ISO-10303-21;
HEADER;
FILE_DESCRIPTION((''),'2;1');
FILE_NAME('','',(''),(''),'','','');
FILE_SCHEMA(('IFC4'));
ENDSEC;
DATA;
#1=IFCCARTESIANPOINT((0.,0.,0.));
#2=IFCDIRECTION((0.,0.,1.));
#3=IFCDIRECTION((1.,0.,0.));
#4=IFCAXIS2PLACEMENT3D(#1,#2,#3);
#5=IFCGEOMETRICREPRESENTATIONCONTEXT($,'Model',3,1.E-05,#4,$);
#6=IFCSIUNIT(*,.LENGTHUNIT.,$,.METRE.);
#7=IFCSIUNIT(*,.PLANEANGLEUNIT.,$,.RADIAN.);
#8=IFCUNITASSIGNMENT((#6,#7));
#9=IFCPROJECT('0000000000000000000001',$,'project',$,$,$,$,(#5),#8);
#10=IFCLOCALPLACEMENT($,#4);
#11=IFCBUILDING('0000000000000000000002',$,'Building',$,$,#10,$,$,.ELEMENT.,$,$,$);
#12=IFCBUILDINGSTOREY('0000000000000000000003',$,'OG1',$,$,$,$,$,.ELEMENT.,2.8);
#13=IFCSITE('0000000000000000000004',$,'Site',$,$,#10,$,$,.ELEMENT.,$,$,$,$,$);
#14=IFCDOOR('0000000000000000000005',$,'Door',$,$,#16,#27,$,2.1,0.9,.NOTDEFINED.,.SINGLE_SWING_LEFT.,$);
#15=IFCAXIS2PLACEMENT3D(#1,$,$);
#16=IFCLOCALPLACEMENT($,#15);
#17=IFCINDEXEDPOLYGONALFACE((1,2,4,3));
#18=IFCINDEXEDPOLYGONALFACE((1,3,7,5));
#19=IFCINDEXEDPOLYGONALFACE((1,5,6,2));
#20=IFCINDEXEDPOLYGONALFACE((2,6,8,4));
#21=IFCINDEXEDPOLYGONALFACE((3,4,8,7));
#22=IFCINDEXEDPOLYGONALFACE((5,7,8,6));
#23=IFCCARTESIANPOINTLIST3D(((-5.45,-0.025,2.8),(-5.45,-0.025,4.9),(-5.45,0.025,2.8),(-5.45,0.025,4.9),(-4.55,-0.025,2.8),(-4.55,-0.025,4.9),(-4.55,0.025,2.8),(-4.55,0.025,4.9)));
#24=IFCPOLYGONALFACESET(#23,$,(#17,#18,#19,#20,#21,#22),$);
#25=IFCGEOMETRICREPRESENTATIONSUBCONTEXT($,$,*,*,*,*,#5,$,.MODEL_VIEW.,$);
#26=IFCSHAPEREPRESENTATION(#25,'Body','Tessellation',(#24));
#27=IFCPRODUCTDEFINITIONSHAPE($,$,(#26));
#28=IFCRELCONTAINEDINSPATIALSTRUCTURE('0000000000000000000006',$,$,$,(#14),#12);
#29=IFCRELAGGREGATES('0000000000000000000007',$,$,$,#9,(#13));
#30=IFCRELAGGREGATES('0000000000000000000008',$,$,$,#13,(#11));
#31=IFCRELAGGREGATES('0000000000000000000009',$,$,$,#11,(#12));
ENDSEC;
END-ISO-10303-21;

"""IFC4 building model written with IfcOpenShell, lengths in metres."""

from ifc_helpers import new_model, si_unit, frame, origin, origin_with_axes, origin_2d, place, context, subcontext, project, spatial, rectangle, extrude, element, save


model = new_model("IFC4")

# Units and contexts
model_context = context("Model", 3, precision=1e-05, world=origin_with_axes())
sub_context = subcontext(model_context, None, None, "MODEL_VIEW")
ifc_project = project(units=[si_unit("LENGTHUNIT", "METRE"), si_unit("PLANEANGLEUNIT", "RADIAN")], contexts=[model_context])

# Site, building, storey
placement_1 = place(None, origin_with_axes())
site = spatial("IfcSite", under=ifc_project, at=placement_1, Name="Site", CompositionType="ELEMENT")
building = spatial("IfcBuilding", under=site, at=placement_1, Name="Building", CompositionType="ELEMENT")
storey = spatial("IfcBuildingStorey", under=building, Name="OG1", CompositionType="ELEMENT", Elevation=2.8)

# Door
placement_2 = place(None, origin_with_axes())
door_placement = place(placement_2, frame((-5.0, 0.0, 2.8)))
element("IfcDoor", 1, at=door_placement, inside=storey, Name="Door", OperationType="SINGLE_SWING_LEFT", OverallHeight=2.1, OverallWidth=0.9, PredefinedType="NOTDEFINED", context=sub_context, shape_type="SweptSolid", body=[
    extrude(rectangle(XDim=0.9, YDim=0.05, at=origin_2d()), origin(), (0.0, 0.0, 1.0), 2.1),
])

save(model, "model.ifc")
